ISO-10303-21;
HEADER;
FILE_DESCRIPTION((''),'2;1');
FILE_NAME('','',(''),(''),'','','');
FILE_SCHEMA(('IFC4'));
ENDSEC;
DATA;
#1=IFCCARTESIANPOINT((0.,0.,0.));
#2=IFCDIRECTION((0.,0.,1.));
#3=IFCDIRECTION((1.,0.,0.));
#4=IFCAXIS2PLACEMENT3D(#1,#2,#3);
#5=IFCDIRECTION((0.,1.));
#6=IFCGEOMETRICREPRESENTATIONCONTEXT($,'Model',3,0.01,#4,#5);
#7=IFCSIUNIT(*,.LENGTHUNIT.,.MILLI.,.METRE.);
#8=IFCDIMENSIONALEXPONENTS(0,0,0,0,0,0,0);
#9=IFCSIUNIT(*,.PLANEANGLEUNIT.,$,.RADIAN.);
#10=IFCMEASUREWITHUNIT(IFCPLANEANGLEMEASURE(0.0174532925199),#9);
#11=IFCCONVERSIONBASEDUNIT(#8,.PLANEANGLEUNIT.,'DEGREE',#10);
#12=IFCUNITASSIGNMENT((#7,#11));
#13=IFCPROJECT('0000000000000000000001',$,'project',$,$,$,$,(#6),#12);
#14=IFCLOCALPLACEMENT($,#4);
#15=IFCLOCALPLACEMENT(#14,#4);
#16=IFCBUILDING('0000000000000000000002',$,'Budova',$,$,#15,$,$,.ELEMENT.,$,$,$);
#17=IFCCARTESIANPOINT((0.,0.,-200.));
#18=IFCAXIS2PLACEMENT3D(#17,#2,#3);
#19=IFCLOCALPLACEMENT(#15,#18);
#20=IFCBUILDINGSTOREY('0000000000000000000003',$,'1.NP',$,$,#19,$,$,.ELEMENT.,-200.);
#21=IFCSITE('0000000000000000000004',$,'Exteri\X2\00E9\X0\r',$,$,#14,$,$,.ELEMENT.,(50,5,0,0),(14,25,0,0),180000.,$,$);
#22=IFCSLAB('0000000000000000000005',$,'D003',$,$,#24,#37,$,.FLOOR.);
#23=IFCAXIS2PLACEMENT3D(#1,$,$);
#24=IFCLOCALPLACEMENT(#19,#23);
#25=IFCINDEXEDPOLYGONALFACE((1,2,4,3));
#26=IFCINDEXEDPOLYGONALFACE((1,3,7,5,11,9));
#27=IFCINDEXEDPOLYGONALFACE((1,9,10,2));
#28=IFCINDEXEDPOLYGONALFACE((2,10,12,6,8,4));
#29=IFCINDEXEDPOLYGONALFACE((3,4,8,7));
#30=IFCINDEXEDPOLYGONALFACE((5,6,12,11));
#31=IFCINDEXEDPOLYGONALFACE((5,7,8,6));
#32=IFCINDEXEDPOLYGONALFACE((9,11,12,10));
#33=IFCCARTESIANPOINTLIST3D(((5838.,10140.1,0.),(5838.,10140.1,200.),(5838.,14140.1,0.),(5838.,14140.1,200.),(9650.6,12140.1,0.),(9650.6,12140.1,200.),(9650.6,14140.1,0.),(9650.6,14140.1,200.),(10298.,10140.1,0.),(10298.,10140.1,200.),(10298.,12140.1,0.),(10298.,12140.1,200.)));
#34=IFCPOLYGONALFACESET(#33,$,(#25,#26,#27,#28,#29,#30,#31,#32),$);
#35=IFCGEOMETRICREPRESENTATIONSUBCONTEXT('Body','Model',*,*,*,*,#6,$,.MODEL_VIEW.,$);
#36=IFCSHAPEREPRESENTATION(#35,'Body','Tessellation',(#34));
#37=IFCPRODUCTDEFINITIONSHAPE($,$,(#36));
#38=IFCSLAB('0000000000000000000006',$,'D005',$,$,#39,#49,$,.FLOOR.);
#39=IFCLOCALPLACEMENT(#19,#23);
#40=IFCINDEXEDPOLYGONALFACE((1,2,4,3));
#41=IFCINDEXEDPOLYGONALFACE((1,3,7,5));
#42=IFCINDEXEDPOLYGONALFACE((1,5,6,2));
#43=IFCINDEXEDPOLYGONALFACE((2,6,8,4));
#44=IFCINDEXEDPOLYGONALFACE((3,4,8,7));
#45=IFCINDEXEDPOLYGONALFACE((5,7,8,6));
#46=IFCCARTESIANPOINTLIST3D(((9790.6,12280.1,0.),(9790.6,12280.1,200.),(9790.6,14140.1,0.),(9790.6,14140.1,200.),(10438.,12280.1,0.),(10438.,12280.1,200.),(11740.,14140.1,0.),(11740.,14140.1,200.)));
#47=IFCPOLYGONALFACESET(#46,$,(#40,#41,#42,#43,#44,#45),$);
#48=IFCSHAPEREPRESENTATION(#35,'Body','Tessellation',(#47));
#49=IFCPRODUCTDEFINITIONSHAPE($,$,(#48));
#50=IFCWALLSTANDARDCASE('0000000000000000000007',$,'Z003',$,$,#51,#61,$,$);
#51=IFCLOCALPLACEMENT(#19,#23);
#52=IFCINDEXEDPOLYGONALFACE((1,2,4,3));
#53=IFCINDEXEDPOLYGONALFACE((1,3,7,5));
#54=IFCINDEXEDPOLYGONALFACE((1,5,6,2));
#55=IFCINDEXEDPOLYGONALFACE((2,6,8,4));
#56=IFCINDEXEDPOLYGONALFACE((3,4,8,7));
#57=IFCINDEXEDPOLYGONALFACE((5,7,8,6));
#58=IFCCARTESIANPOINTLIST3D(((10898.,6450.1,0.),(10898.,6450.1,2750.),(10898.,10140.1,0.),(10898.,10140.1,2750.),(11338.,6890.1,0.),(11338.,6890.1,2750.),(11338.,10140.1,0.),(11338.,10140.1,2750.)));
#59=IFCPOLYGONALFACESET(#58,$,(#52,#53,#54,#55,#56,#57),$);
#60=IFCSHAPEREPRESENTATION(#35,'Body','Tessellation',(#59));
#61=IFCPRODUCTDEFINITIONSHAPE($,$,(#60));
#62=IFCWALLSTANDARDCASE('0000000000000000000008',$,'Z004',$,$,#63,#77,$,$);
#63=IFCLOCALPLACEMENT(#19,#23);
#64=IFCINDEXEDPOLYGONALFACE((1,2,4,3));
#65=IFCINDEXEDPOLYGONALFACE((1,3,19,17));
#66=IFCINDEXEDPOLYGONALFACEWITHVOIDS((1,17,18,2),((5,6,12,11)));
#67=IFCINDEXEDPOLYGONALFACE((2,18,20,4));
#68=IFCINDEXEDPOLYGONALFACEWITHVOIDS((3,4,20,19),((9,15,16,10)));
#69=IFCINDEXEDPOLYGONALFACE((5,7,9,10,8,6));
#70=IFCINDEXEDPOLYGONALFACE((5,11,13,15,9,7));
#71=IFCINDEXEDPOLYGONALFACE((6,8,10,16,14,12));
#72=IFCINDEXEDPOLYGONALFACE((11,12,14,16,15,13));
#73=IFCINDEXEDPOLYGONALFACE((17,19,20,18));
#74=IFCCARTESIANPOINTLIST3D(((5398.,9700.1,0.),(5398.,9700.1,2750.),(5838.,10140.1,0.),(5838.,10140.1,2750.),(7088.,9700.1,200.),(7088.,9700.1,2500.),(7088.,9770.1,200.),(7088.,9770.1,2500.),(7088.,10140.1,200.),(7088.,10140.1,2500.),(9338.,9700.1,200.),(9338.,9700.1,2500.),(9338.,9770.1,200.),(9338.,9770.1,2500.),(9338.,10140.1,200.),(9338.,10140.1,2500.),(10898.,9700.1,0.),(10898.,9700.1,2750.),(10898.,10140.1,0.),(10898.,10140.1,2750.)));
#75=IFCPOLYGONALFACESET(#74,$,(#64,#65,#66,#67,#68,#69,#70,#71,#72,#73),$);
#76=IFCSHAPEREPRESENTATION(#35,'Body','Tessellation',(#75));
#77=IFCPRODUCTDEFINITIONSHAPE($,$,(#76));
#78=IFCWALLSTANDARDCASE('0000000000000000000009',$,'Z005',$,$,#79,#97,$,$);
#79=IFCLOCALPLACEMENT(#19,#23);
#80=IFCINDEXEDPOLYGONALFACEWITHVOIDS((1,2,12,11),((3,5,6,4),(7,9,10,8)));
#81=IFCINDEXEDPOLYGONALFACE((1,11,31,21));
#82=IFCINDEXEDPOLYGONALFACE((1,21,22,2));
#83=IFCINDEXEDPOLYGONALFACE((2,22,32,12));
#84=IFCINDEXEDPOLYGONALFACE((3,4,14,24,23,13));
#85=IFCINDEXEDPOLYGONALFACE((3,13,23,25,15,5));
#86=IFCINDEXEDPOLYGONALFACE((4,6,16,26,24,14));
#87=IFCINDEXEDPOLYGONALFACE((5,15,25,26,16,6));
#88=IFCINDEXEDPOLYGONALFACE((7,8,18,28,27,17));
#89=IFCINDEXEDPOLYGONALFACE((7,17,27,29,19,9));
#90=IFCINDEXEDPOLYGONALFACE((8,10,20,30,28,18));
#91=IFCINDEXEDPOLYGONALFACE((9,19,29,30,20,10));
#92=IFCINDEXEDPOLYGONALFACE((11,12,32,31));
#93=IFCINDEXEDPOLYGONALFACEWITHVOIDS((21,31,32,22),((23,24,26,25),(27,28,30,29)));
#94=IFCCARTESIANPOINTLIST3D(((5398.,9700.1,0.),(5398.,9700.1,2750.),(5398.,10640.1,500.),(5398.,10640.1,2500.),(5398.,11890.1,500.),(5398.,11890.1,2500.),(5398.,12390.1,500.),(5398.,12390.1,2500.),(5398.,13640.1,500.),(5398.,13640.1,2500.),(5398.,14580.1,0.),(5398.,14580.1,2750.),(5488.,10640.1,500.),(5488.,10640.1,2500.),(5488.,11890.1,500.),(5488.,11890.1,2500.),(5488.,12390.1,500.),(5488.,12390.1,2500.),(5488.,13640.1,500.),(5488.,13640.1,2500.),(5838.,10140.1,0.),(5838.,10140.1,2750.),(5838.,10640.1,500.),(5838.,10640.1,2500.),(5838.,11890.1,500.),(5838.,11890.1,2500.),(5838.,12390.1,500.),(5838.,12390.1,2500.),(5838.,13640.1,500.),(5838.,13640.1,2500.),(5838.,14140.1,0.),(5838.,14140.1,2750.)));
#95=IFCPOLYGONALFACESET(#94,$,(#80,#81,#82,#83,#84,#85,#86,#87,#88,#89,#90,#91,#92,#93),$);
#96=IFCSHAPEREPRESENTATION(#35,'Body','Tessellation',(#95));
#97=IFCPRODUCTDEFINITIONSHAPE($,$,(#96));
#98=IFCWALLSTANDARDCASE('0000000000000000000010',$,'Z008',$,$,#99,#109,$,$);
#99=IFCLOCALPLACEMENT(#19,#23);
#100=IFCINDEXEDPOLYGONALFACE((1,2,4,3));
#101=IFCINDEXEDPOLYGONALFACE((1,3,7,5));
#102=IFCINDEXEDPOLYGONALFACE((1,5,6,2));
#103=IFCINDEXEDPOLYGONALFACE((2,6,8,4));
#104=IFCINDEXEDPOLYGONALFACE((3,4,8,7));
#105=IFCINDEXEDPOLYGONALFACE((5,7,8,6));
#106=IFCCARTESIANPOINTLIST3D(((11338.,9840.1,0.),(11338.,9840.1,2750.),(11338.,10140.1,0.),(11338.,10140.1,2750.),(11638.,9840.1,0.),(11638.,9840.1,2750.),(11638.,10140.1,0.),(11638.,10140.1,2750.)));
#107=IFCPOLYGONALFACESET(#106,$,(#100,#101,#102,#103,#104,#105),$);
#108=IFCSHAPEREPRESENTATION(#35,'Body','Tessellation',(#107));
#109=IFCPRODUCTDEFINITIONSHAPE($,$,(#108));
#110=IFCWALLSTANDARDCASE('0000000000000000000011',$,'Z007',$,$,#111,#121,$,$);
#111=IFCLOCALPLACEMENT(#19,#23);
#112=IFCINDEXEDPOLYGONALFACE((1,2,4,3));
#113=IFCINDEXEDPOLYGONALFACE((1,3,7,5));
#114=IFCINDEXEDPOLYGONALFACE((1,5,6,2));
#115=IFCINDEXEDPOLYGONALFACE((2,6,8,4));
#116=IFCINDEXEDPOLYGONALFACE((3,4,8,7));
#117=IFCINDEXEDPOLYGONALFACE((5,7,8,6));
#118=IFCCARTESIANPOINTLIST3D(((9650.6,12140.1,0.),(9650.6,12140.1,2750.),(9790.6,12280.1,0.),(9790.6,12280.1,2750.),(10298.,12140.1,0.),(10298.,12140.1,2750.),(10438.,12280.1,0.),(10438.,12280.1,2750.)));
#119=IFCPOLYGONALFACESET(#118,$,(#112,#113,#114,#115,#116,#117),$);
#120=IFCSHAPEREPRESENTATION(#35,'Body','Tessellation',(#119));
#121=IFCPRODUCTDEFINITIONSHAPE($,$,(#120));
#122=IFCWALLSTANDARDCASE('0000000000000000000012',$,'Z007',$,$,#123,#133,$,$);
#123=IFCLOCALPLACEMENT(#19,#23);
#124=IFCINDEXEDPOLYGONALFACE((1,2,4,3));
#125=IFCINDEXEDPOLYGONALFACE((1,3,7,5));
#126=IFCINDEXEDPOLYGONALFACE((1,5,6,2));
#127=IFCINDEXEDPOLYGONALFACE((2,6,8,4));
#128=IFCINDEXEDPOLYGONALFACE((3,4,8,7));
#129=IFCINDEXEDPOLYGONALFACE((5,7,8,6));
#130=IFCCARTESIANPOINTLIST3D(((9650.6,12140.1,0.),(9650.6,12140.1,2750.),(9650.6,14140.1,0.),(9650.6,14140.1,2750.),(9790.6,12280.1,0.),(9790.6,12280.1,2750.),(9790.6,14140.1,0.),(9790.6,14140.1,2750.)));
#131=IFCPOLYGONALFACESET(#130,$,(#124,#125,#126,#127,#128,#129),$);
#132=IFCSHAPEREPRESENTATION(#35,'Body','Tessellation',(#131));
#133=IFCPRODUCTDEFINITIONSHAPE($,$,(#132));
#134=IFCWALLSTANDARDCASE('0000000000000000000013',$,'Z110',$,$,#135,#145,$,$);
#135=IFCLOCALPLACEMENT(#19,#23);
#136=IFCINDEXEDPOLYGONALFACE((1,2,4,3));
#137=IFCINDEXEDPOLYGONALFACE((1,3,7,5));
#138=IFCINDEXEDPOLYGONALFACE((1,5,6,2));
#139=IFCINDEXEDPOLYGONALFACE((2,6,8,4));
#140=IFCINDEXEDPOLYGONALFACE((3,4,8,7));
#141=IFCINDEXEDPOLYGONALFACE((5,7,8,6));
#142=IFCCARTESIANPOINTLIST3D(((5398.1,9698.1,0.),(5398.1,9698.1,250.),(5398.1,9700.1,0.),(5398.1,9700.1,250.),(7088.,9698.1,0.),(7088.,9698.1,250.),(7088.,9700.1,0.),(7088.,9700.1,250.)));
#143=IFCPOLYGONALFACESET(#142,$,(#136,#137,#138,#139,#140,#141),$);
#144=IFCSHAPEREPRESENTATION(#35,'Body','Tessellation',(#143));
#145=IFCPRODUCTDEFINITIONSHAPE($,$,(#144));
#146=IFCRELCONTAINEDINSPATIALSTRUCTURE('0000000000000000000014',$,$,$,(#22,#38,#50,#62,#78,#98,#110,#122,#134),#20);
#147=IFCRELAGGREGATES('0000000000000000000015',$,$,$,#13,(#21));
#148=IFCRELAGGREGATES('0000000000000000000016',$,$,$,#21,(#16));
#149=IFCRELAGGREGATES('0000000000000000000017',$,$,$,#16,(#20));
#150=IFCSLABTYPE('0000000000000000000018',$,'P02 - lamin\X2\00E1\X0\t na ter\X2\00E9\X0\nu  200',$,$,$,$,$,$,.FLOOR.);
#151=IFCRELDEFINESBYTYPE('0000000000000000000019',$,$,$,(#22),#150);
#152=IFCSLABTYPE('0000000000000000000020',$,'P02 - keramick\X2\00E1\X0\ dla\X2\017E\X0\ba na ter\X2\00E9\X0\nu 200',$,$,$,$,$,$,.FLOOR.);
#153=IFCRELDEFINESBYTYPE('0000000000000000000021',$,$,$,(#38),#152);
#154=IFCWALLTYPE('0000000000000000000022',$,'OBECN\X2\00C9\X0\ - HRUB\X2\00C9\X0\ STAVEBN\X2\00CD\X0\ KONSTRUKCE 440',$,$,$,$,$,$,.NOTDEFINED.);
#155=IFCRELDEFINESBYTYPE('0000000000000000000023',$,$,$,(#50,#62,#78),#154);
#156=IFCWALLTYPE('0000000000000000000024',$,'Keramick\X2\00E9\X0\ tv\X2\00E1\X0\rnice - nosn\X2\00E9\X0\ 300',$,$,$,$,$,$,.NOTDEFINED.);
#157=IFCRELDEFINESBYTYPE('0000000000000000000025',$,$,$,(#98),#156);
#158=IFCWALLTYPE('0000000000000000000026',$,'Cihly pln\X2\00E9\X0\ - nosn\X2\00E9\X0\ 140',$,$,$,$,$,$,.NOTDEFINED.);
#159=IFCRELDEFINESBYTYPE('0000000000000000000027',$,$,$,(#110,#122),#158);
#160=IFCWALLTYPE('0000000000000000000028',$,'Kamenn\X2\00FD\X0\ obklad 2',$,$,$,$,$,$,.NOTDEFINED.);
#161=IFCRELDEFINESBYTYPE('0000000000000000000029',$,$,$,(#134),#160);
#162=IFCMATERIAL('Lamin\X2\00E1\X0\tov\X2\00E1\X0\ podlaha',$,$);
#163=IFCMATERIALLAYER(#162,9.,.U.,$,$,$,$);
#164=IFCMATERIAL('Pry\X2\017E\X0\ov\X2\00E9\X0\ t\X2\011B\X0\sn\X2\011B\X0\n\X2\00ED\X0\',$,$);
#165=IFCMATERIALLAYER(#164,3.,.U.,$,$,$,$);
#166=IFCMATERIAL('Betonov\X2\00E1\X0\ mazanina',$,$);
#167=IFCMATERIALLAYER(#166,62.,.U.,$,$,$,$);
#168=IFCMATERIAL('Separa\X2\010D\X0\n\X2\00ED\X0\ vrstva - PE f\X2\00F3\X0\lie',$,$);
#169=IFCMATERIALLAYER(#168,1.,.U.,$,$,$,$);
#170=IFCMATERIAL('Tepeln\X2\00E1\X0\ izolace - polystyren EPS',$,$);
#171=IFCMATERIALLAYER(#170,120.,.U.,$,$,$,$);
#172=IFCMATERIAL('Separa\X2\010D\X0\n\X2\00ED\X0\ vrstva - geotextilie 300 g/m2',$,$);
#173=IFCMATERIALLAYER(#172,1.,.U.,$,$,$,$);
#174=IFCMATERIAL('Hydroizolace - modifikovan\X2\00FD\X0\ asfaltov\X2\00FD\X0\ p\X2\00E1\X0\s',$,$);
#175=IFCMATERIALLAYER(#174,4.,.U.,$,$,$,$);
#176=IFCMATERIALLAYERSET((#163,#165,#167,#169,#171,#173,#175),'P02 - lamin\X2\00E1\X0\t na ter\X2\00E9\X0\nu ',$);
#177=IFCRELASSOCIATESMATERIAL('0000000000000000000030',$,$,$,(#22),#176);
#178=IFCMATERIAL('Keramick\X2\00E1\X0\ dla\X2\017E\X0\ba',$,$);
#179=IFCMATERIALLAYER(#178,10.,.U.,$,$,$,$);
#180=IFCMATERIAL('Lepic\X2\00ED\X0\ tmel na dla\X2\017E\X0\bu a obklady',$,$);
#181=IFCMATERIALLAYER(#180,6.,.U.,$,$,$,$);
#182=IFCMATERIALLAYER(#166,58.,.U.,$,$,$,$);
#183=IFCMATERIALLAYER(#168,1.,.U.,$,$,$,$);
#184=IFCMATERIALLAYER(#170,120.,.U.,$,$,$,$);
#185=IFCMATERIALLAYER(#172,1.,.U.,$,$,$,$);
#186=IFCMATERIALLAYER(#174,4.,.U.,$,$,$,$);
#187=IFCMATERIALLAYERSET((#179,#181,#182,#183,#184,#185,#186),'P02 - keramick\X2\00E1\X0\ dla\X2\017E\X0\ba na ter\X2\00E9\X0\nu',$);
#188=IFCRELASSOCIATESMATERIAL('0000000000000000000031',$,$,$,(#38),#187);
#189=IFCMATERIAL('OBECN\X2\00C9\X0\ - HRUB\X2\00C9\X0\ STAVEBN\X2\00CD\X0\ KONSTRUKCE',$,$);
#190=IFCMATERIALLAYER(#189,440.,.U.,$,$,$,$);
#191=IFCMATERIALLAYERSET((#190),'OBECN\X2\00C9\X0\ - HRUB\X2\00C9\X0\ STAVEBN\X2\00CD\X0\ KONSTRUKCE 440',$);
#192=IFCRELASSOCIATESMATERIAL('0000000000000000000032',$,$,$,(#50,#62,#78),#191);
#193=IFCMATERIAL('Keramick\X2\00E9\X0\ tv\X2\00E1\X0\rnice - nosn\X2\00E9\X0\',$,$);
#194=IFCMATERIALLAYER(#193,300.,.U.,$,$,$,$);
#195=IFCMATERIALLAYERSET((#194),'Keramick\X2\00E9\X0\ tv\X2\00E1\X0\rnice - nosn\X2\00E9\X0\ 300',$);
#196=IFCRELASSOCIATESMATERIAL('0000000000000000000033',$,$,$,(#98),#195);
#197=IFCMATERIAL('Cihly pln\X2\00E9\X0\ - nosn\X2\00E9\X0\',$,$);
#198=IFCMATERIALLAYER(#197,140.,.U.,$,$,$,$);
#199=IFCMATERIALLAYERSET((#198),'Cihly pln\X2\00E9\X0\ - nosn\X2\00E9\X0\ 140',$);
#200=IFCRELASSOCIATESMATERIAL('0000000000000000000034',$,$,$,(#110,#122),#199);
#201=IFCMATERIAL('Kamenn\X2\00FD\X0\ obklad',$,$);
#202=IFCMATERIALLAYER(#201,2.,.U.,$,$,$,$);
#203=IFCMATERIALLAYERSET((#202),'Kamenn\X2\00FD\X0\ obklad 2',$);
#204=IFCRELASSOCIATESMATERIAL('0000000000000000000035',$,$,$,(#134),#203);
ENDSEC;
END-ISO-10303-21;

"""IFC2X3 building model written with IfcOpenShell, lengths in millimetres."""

from ifc_helpers import new_model, entity, si_unit, converted_unit, direction, frame, origin_with_axes, origin_2d_with_axis, place, context, subcontext, project, spatial, polyline, rectangle, outline, extrude, material, layer, layer_set, layer_usage, type_object, element, save


model = new_model("IFC2X3")

# Units and contexts
model_context = context("Model", 3, precision=0.01, world=origin_with_axes(), true_north=direction((0.0, 1.0)))
body_context = subcontext(model_context, "Body", "Model", "MODEL_VIEW")
ifc_project = project(units=[si_unit("LENGTHUNIT", "METRE", prefix="MILLI"), converted_unit("PLANEANGLEUNIT", "DEGREE", entity("IfcPlaneAngleMeasure", 0.0174532925199), si_unit("PLANEANGLEUNIT", "RADIAN"), dimensions=[0, 0, 0, 0, 0, 0, 0])], contexts=[model_context])

# Site, building, storey
site_placement = place(None, origin_with_axes())
site = spatial("IfcSite", under=ifc_project, at=site_placement, Name="Exteriér", CompositionType="ELEMENT", RefLatitude=(50, 5, 0, 0), RefLongitude=(14, 25, 0, 0), RefElevation=180000.0)
building_placement = place(site_placement, origin_with_axes())
building = spatial("IfcBuilding", under=site, at=building_placement, Name="Budova", CompositionType="ELEMENT")
storey_placement = place(building_placement, frame((0.0, 0.0, -200.0), z_axis=(0.0, 0.0, 1.0), x_axis=(1.0, 0.0, 0.0)))
storey = spatial("IfcBuildingStorey", under=building, at=storey_placement, Name="1.NP", CompositionType="ELEMENT", Elevation=-200.0)

# Slabs
ifc_material_1 = material(Name="Laminátová podlaha")
ifc_layer_1 = layer(ifc_material_1, 9.0, ventilated="UNKNOWN")
ifc_material_2 = material(Name="Pryžové těsnění")
ifc_layer_2 = layer(ifc_material_2, 3.0, ventilated="UNKNOWN")
ifc_material_3 = material(Name="Betonová mazanina")
ifc_layer_3 = layer(ifc_material_3, 62.0, ventilated="UNKNOWN")
ifc_material_4 = material(Name="Separační vrstva - PE fólie")
ifc_layer_4 = layer(ifc_material_4, 1.0, ventilated="UNKNOWN")
ifc_material_5 = material(Name="Tepelná izolace - polystyren EPS")
ifc_layer_5 = layer(ifc_material_5, 120.0, ventilated="UNKNOWN")
ifc_material_6 = material(Name="Separační vrstva - geotextilie 300 g/m2")
ifc_layer_6 = layer(ifc_material_6, 1.0, ventilated="UNKNOWN")
ifc_material_7 = material(Name="Hydroizolace - modifikovaný asfaltový pás")
ifc_layer_7 = layer(ifc_material_7, 4.0, ventilated="UNKNOWN")
ifc_layer_set_1 = layer_set([ifc_layer_1, ifc_layer_2, ifc_layer_3, ifc_layer_4, ifc_layer_5, ifc_layer_6, ifc_layer_7], Name="P02 - laminát na terénu ")
ifc_layer_usage_1 = layer_usage(ifc_layer_set_1, "AXIS3", "NEGATIVE", 200.0)
slab_type_1 = type_object("IfcSlabType", Name="P02 - laminát na terénu  200", PredefinedType="FLOOR")
slab_1_placement = place(storey_placement, frame((5838.0, 14140.1, 0.0), z_axis=(0.0, 0.0, 1.0), x_axis=(1.0, 0.0, 0.0)))
element("IfcSlab", 1, at=slab_1_placement, inside=storey, type_object=slab_type_1, material=ifc_layer_usage_1, Name="D003", PredefinedType="FLOOR", context=body_context, shape_type="SweptSolid", body=[
    extrude(outline(polyline([(0.0, 0.0), (0.0, -4000.0), (4460.0, -4000.0), (4460.0, -2000.0), (3812.6, -2000.0), (3812.6, 0.0), (0.0, 0.0)])), origin_with_axes(), (0.0, 0.0, 1.0), 200.0),
])
ifc_material_8 = material(Name="Keramická dlažba")
ifc_layer_8 = layer(ifc_material_8, 10.0, ventilated="UNKNOWN")
ifc_material_9 = material(Name="Lepicí tmel na dlažbu a obklady")
ifc_layer_9 = layer(ifc_material_9, 6.0, ventilated="UNKNOWN")
ifc_layer_10 = layer(ifc_material_3, 58.0, ventilated="UNKNOWN")
ifc_layer_11 = layer(ifc_material_4, 1.0, ventilated="UNKNOWN")
ifc_layer_12 = layer(ifc_material_5, 120.0, ventilated="UNKNOWN")
ifc_layer_13 = layer(ifc_material_6, 1.0, ventilated="UNKNOWN")
ifc_layer_14 = layer(ifc_material_7, 4.0, ventilated="UNKNOWN")
ifc_layer_set_2 = layer_set([ifc_layer_8, ifc_layer_9, ifc_layer_10, ifc_layer_11, ifc_layer_12, ifc_layer_13, ifc_layer_14], Name="P02 - keramická dlažba na terénu")
ifc_layer_usage_2 = layer_usage(ifc_layer_set_2, "AXIS3", "NEGATIVE", 200.0)
slab_type_2 = type_object("IfcSlabType", Name="P02 - keramická dlažba na terénu 200", PredefinedType="FLOOR")
slab_2_placement = place(storey_placement, frame((9790.6, 12280.1, 0.0), z_axis=(0.0, 0.0, 1.0), x_axis=(1.0, 0.0, 0.0)))
element("IfcSlab", 2, at=slab_2_placement, inside=storey, type_object=slab_type_2, material=ifc_layer_usage_2, Name="D005", PredefinedType="FLOOR", context=body_context, shape_type="SweptSolid", body=[
    extrude(outline(polyline([(0.0, 0.0), (647.4, 0.0), (1949.5, 1860.0), (0.0, 1860.0), (0.0, 0.0)])), origin_with_axes(), (0.0, 0.0, 1.0), 200.0),
])

# Wall
ifc_material_10 = material(Name="OBECNÉ - HRUBÉ STAVEBNÍ KONSTRUKCE")
ifc_layer_15 = layer(ifc_material_10, 440.0, ventilated="UNKNOWN")
ifc_layer_set_3 = layer_set([ifc_layer_15], Name="OBECNÉ - HRUBÉ STAVEBNÍ KONSTRUKCE 440")
ifc_layer_usage_3 = layer_usage(ifc_layer_set_3, "AXIS2", "NEGATIVE", 0.0)
wall_type_1 = type_object("IfcWallType", Name="OBECNÉ - HRUBÉ STAVEBNÍ KONSTRUKCE 440", PredefinedType="NOTDEFINED")
wall_1_placement = place(storey_placement, frame((10898.0, 6450.1, 0.0), z_axis=(0.0, 0.0, 1.0), x_axis=(0.0, 1.0, 0.0)))
element("IfcWallStandardCase", 3, at=wall_1_placement, inside=storey, type_object=wall_type_1, material=ifc_layer_usage_3, Name="Z003", context=body_context, shape_type="SweptSolid", body=[
    extrude(outline(polyline([(440.0, -440.0), (3690.0, -440.0), (3690.0, 0.0), (0.0, 0.0), (440.0, -440.0)])), origin_with_axes(), (0.0, 0.0, 1.0), 2750.0),
])

# Wall, opening
ifc_layer_usage_4 = layer_usage(ifc_layer_set_3, "AXIS2", "NEGATIVE", 0.0)
wall_2_placement = place(storey_placement, frame((10898.0, 9700.1, 0.0), z_axis=(0.0, 0.0, 1.0), x_axis=(-1.0, 0.0, 0.0)))
wall_2 = element("IfcWallStandardCase", 4, at=wall_2_placement, inside=storey, type_object=wall_type_1, material=ifc_layer_usage_4, Name="Z004", context=body_context, shape_type="SweptSolid", body=[
    extrude(outline(polyline([(0.0, -440.0), (5060.0, -440.0), (5500.0, 0.0), (0.0, 0.0), (0.0, -440.0)])), origin_with_axes(), (0.0, 0.0, 1.0), 2750.0),
])
opening_1_placement = place(wall_2_placement, frame((2685.0, 0.0, 200.0), z_axis=(0.0, 0.0, 1.0), x_axis=(1.0, 0.0, 0.0)))
element("IfcOpeningElement", 5, at=opening_1_placement, cuts=wall_2, context=body_context, shape_type="SweptSolid", body=[
    extrude(rectangle(XDim=2250.0, YDim=2300.0, at=origin_2d_with_axis()), frame((0.0, -70.0, 1150.0), z_axis=(0.0, -1.0, 0.0), x_axis=(1.0, 0.0, 0.0)), (0.0, 0.0, 1.0), 810.0),
    extrude(rectangle(XDim=2250.0, YDim=2300.0, at=origin_2d_with_axis()), frame((0.0, -70.0, 1150.0), z_axis=(0.0, 1.0, 0.0), x_axis=(1.0, 0.0, 0.0)), (0.0, 0.0, 1.0), 510.0),
])

# Wall, openings
ifc_layer_usage_5 = layer_usage(ifc_layer_set_3, "AXIS2", "NEGATIVE", 0.0)
wall_3_placement = place(storey_placement, frame((5398.0, 9700.1, 0.0), z_axis=(0.0, 0.0, 1.0), x_axis=(0.0, 1.0, 0.0)))
wall_3 = element("IfcWallStandardCase", 6, at=wall_3_placement, inside=storey, type_object=wall_type_1, material=ifc_layer_usage_5, Name="Z005", context=body_context, shape_type="SweptSolid", body=[
    extrude(outline(polyline([(440.0, -440.0), (4440.0, -440.0), (4880.0, 0.0), (0.0, 0.0), (440.0, -440.0)])), origin_with_axes(), (0.0, 0.0, 1.0), 2750.0),
])
opening_2_placement = place(wall_3_placement, frame((3315.0, 0.0, 500.0), z_axis=(0.0, 0.0, 1.0), x_axis=(1.0, 0.0, 0.0)))
element("IfcOpeningElement", 7, at=opening_2_placement, cuts=wall_3, context=body_context, shape_type="SweptSolid", body=[
    extrude(rectangle(XDim=1250.0, YDim=2000.0, at=origin_2d_with_axis()), frame((0.0, -90.0, 1000.0), z_axis=(0.0, 1.0, 0.0), x_axis=(-1.0, 0.0, 0.0)), (0.0, 0.0, -1.0), 790.0),
    extrude(rectangle(XDim=1250.0, YDim=2000.0, at=origin_2d_with_axis()), frame((0.0, -90.0, 1000.0), z_axis=(0.0, -1.0, 0.0), x_axis=(-1.0, 0.0, 0.0)), (0.0, 0.0, -1.0), 530.0),
])
opening_3_placement = place(wall_3_placement, frame((1565.0, 0.0, 500.0), z_axis=(0.0, 0.0, 1.0), x_axis=(1.0, 0.0, 0.0)))
element("IfcOpeningElement", 8, at=opening_3_placement, cuts=wall_3, context=body_context, shape_type="SweptSolid", body=[
    extrude(rectangle(XDim=1250.0, YDim=2000.0, at=origin_2d_with_axis()), frame((0.0, -90.0, 1000.0), z_axis=(0.0, 1.0, 0.0), x_axis=(-1.0, 0.0, 0.0)), (0.0, 0.0, -1.0), 790.0),
    extrude(rectangle(XDim=1250.0, YDim=2000.0, at=origin_2d_with_axis()), frame((0.0, -90.0, 1000.0), z_axis=(0.0, -1.0, 0.0), x_axis=(-1.0, 0.0, 0.0)), (0.0, 0.0, -1.0), 530.0),
])

# Walls
ifc_material_11 = material(Name="Keramické tvárnice - nosné")
ifc_layer_16 = layer(ifc_material_11, 300.0, ventilated="UNKNOWN")
ifc_layer_set_4 = layer_set([ifc_layer_16], Name="Keramické tvárnice - nosné 300")
ifc_layer_usage_6 = layer_usage(ifc_layer_set_4, "AXIS2", "POSITIVE", -300.0)
wall_type_2 = type_object("IfcWallType", Name="Keramické tvárnice - nosné 300", PredefinedType="NOTDEFINED")
wall_4_placement = place(storey_placement, frame((11338.0, 10140.1, 0.0), z_axis=(0.0, 0.0, 1.0), x_axis=(1.0, 0.0, 0.0)))
element("IfcWallStandardCase", 9, at=wall_4_placement, inside=storey, type_object=wall_type_2, material=ifc_layer_usage_6, Name="Z008", context=body_context, shape_type="SweptSolid", body=[
    extrude(outline(polyline([(0.0, -300.0), (300.0, -300.0), (300.0, 0.0), (0.0, 0.0), (0.0, -300.0)])), origin_with_axes(), (0.0, 0.0, 1.0), 2750.0),
])
ifc_material_12 = material(Name="Cihly plné - nosné")
ifc_layer_17 = layer(ifc_material_12, 140.0, ventilated="UNKNOWN")
ifc_layer_set_5 = layer_set([ifc_layer_17], Name="Cihly plné - nosné 140")
ifc_layer_usage_7 = layer_usage(ifc_layer_set_5, "AXIS2", "POSITIVE", 0.0)
wall_type_3 = type_object("IfcWallType", Name="Cihly plné - nosné 140", PredefinedType="NOTDEFINED")
wall_5_placement = place(storey_placement, frame((9790.6, 12140.1, 0.0), z_axis=(0.0, 0.0, 1.0), x_axis=(1.0, 0.0, 0.0)))
element("IfcWallStandardCase", 10, at=wall_5_placement, inside=storey, type_object=wall_type_3, material=ifc_layer_usage_7, Name="Z007", context=body_context, shape_type="SweptSolid", body=[
    extrude(outline(polyline([(-140.0, 0.0), (507.4, 0.0), (647.4, 140.0), (0.0, 140.0), (-140.0, 0.0)])), origin_with_axes(), (0.0, 0.0, 1.0), 2750.0),
])
ifc_layer_usage_8 = layer_usage(ifc_layer_set_5, "AXIS2", "POSITIVE", 0.0)
wall_6_placement = place(storey_placement, frame((9790.6, 12140.1, 0.0), z_axis=(0.0, 0.0, 1.0), x_axis=(0.0, 1.0, 0.0)))
element("IfcWallStandardCase", 11, at=wall_6_placement, inside=storey, type_object=wall_type_3, material=ifc_layer_usage_8, Name="Z007", context=body_context, shape_type="SweptSolid", body=[
    extrude(outline(polyline([(140.0, 0.0), (2000.0, 0.0), (2000.0, 140.0), (0.0, 140.0), (140.0, 0.0)])), origin_with_axes(), (0.0, 0.0, 1.0), 2750.0),
])

# Wall
ifc_material_13 = material(Name="Kamenný obklad")
ifc_layer_18 = layer(ifc_material_13, 2.0, ventilated="UNKNOWN")
ifc_layer_set_6 = layer_set([ifc_layer_18], Name="Kamenný obklad 2")
ifc_layer_usage_9 = layer_usage(ifc_layer_set_6, "AXIS2", "POSITIVE", -2.0)
wall_type_4 = type_object("IfcWallType", Name="Kamenný obklad 2", PredefinedType="NOTDEFINED")
wall_7_placement = place(storey_placement, frame((5398.1, 9700.1, 0.0), z_axis=(0.0, 0.0, 1.0), x_axis=(1.0, 0.0, 0.0)))
element("IfcWallStandardCase", 12, at=wall_7_placement, inside=storey, type_object=wall_type_4, material=ifc_layer_usage_9, Name="Z110", context=body_context, shape_type="SweptSolid", body=[
    extrude(outline(polyline([(0.0, -2.0), (1689.9, -2.0), (1689.9, 0.0), (0.0, 0.0), (0.0, -2.0)])), origin_with_axes(), (0.0, 0.0, 1.0), 250.0),
])

save(model, "model.ifc")
